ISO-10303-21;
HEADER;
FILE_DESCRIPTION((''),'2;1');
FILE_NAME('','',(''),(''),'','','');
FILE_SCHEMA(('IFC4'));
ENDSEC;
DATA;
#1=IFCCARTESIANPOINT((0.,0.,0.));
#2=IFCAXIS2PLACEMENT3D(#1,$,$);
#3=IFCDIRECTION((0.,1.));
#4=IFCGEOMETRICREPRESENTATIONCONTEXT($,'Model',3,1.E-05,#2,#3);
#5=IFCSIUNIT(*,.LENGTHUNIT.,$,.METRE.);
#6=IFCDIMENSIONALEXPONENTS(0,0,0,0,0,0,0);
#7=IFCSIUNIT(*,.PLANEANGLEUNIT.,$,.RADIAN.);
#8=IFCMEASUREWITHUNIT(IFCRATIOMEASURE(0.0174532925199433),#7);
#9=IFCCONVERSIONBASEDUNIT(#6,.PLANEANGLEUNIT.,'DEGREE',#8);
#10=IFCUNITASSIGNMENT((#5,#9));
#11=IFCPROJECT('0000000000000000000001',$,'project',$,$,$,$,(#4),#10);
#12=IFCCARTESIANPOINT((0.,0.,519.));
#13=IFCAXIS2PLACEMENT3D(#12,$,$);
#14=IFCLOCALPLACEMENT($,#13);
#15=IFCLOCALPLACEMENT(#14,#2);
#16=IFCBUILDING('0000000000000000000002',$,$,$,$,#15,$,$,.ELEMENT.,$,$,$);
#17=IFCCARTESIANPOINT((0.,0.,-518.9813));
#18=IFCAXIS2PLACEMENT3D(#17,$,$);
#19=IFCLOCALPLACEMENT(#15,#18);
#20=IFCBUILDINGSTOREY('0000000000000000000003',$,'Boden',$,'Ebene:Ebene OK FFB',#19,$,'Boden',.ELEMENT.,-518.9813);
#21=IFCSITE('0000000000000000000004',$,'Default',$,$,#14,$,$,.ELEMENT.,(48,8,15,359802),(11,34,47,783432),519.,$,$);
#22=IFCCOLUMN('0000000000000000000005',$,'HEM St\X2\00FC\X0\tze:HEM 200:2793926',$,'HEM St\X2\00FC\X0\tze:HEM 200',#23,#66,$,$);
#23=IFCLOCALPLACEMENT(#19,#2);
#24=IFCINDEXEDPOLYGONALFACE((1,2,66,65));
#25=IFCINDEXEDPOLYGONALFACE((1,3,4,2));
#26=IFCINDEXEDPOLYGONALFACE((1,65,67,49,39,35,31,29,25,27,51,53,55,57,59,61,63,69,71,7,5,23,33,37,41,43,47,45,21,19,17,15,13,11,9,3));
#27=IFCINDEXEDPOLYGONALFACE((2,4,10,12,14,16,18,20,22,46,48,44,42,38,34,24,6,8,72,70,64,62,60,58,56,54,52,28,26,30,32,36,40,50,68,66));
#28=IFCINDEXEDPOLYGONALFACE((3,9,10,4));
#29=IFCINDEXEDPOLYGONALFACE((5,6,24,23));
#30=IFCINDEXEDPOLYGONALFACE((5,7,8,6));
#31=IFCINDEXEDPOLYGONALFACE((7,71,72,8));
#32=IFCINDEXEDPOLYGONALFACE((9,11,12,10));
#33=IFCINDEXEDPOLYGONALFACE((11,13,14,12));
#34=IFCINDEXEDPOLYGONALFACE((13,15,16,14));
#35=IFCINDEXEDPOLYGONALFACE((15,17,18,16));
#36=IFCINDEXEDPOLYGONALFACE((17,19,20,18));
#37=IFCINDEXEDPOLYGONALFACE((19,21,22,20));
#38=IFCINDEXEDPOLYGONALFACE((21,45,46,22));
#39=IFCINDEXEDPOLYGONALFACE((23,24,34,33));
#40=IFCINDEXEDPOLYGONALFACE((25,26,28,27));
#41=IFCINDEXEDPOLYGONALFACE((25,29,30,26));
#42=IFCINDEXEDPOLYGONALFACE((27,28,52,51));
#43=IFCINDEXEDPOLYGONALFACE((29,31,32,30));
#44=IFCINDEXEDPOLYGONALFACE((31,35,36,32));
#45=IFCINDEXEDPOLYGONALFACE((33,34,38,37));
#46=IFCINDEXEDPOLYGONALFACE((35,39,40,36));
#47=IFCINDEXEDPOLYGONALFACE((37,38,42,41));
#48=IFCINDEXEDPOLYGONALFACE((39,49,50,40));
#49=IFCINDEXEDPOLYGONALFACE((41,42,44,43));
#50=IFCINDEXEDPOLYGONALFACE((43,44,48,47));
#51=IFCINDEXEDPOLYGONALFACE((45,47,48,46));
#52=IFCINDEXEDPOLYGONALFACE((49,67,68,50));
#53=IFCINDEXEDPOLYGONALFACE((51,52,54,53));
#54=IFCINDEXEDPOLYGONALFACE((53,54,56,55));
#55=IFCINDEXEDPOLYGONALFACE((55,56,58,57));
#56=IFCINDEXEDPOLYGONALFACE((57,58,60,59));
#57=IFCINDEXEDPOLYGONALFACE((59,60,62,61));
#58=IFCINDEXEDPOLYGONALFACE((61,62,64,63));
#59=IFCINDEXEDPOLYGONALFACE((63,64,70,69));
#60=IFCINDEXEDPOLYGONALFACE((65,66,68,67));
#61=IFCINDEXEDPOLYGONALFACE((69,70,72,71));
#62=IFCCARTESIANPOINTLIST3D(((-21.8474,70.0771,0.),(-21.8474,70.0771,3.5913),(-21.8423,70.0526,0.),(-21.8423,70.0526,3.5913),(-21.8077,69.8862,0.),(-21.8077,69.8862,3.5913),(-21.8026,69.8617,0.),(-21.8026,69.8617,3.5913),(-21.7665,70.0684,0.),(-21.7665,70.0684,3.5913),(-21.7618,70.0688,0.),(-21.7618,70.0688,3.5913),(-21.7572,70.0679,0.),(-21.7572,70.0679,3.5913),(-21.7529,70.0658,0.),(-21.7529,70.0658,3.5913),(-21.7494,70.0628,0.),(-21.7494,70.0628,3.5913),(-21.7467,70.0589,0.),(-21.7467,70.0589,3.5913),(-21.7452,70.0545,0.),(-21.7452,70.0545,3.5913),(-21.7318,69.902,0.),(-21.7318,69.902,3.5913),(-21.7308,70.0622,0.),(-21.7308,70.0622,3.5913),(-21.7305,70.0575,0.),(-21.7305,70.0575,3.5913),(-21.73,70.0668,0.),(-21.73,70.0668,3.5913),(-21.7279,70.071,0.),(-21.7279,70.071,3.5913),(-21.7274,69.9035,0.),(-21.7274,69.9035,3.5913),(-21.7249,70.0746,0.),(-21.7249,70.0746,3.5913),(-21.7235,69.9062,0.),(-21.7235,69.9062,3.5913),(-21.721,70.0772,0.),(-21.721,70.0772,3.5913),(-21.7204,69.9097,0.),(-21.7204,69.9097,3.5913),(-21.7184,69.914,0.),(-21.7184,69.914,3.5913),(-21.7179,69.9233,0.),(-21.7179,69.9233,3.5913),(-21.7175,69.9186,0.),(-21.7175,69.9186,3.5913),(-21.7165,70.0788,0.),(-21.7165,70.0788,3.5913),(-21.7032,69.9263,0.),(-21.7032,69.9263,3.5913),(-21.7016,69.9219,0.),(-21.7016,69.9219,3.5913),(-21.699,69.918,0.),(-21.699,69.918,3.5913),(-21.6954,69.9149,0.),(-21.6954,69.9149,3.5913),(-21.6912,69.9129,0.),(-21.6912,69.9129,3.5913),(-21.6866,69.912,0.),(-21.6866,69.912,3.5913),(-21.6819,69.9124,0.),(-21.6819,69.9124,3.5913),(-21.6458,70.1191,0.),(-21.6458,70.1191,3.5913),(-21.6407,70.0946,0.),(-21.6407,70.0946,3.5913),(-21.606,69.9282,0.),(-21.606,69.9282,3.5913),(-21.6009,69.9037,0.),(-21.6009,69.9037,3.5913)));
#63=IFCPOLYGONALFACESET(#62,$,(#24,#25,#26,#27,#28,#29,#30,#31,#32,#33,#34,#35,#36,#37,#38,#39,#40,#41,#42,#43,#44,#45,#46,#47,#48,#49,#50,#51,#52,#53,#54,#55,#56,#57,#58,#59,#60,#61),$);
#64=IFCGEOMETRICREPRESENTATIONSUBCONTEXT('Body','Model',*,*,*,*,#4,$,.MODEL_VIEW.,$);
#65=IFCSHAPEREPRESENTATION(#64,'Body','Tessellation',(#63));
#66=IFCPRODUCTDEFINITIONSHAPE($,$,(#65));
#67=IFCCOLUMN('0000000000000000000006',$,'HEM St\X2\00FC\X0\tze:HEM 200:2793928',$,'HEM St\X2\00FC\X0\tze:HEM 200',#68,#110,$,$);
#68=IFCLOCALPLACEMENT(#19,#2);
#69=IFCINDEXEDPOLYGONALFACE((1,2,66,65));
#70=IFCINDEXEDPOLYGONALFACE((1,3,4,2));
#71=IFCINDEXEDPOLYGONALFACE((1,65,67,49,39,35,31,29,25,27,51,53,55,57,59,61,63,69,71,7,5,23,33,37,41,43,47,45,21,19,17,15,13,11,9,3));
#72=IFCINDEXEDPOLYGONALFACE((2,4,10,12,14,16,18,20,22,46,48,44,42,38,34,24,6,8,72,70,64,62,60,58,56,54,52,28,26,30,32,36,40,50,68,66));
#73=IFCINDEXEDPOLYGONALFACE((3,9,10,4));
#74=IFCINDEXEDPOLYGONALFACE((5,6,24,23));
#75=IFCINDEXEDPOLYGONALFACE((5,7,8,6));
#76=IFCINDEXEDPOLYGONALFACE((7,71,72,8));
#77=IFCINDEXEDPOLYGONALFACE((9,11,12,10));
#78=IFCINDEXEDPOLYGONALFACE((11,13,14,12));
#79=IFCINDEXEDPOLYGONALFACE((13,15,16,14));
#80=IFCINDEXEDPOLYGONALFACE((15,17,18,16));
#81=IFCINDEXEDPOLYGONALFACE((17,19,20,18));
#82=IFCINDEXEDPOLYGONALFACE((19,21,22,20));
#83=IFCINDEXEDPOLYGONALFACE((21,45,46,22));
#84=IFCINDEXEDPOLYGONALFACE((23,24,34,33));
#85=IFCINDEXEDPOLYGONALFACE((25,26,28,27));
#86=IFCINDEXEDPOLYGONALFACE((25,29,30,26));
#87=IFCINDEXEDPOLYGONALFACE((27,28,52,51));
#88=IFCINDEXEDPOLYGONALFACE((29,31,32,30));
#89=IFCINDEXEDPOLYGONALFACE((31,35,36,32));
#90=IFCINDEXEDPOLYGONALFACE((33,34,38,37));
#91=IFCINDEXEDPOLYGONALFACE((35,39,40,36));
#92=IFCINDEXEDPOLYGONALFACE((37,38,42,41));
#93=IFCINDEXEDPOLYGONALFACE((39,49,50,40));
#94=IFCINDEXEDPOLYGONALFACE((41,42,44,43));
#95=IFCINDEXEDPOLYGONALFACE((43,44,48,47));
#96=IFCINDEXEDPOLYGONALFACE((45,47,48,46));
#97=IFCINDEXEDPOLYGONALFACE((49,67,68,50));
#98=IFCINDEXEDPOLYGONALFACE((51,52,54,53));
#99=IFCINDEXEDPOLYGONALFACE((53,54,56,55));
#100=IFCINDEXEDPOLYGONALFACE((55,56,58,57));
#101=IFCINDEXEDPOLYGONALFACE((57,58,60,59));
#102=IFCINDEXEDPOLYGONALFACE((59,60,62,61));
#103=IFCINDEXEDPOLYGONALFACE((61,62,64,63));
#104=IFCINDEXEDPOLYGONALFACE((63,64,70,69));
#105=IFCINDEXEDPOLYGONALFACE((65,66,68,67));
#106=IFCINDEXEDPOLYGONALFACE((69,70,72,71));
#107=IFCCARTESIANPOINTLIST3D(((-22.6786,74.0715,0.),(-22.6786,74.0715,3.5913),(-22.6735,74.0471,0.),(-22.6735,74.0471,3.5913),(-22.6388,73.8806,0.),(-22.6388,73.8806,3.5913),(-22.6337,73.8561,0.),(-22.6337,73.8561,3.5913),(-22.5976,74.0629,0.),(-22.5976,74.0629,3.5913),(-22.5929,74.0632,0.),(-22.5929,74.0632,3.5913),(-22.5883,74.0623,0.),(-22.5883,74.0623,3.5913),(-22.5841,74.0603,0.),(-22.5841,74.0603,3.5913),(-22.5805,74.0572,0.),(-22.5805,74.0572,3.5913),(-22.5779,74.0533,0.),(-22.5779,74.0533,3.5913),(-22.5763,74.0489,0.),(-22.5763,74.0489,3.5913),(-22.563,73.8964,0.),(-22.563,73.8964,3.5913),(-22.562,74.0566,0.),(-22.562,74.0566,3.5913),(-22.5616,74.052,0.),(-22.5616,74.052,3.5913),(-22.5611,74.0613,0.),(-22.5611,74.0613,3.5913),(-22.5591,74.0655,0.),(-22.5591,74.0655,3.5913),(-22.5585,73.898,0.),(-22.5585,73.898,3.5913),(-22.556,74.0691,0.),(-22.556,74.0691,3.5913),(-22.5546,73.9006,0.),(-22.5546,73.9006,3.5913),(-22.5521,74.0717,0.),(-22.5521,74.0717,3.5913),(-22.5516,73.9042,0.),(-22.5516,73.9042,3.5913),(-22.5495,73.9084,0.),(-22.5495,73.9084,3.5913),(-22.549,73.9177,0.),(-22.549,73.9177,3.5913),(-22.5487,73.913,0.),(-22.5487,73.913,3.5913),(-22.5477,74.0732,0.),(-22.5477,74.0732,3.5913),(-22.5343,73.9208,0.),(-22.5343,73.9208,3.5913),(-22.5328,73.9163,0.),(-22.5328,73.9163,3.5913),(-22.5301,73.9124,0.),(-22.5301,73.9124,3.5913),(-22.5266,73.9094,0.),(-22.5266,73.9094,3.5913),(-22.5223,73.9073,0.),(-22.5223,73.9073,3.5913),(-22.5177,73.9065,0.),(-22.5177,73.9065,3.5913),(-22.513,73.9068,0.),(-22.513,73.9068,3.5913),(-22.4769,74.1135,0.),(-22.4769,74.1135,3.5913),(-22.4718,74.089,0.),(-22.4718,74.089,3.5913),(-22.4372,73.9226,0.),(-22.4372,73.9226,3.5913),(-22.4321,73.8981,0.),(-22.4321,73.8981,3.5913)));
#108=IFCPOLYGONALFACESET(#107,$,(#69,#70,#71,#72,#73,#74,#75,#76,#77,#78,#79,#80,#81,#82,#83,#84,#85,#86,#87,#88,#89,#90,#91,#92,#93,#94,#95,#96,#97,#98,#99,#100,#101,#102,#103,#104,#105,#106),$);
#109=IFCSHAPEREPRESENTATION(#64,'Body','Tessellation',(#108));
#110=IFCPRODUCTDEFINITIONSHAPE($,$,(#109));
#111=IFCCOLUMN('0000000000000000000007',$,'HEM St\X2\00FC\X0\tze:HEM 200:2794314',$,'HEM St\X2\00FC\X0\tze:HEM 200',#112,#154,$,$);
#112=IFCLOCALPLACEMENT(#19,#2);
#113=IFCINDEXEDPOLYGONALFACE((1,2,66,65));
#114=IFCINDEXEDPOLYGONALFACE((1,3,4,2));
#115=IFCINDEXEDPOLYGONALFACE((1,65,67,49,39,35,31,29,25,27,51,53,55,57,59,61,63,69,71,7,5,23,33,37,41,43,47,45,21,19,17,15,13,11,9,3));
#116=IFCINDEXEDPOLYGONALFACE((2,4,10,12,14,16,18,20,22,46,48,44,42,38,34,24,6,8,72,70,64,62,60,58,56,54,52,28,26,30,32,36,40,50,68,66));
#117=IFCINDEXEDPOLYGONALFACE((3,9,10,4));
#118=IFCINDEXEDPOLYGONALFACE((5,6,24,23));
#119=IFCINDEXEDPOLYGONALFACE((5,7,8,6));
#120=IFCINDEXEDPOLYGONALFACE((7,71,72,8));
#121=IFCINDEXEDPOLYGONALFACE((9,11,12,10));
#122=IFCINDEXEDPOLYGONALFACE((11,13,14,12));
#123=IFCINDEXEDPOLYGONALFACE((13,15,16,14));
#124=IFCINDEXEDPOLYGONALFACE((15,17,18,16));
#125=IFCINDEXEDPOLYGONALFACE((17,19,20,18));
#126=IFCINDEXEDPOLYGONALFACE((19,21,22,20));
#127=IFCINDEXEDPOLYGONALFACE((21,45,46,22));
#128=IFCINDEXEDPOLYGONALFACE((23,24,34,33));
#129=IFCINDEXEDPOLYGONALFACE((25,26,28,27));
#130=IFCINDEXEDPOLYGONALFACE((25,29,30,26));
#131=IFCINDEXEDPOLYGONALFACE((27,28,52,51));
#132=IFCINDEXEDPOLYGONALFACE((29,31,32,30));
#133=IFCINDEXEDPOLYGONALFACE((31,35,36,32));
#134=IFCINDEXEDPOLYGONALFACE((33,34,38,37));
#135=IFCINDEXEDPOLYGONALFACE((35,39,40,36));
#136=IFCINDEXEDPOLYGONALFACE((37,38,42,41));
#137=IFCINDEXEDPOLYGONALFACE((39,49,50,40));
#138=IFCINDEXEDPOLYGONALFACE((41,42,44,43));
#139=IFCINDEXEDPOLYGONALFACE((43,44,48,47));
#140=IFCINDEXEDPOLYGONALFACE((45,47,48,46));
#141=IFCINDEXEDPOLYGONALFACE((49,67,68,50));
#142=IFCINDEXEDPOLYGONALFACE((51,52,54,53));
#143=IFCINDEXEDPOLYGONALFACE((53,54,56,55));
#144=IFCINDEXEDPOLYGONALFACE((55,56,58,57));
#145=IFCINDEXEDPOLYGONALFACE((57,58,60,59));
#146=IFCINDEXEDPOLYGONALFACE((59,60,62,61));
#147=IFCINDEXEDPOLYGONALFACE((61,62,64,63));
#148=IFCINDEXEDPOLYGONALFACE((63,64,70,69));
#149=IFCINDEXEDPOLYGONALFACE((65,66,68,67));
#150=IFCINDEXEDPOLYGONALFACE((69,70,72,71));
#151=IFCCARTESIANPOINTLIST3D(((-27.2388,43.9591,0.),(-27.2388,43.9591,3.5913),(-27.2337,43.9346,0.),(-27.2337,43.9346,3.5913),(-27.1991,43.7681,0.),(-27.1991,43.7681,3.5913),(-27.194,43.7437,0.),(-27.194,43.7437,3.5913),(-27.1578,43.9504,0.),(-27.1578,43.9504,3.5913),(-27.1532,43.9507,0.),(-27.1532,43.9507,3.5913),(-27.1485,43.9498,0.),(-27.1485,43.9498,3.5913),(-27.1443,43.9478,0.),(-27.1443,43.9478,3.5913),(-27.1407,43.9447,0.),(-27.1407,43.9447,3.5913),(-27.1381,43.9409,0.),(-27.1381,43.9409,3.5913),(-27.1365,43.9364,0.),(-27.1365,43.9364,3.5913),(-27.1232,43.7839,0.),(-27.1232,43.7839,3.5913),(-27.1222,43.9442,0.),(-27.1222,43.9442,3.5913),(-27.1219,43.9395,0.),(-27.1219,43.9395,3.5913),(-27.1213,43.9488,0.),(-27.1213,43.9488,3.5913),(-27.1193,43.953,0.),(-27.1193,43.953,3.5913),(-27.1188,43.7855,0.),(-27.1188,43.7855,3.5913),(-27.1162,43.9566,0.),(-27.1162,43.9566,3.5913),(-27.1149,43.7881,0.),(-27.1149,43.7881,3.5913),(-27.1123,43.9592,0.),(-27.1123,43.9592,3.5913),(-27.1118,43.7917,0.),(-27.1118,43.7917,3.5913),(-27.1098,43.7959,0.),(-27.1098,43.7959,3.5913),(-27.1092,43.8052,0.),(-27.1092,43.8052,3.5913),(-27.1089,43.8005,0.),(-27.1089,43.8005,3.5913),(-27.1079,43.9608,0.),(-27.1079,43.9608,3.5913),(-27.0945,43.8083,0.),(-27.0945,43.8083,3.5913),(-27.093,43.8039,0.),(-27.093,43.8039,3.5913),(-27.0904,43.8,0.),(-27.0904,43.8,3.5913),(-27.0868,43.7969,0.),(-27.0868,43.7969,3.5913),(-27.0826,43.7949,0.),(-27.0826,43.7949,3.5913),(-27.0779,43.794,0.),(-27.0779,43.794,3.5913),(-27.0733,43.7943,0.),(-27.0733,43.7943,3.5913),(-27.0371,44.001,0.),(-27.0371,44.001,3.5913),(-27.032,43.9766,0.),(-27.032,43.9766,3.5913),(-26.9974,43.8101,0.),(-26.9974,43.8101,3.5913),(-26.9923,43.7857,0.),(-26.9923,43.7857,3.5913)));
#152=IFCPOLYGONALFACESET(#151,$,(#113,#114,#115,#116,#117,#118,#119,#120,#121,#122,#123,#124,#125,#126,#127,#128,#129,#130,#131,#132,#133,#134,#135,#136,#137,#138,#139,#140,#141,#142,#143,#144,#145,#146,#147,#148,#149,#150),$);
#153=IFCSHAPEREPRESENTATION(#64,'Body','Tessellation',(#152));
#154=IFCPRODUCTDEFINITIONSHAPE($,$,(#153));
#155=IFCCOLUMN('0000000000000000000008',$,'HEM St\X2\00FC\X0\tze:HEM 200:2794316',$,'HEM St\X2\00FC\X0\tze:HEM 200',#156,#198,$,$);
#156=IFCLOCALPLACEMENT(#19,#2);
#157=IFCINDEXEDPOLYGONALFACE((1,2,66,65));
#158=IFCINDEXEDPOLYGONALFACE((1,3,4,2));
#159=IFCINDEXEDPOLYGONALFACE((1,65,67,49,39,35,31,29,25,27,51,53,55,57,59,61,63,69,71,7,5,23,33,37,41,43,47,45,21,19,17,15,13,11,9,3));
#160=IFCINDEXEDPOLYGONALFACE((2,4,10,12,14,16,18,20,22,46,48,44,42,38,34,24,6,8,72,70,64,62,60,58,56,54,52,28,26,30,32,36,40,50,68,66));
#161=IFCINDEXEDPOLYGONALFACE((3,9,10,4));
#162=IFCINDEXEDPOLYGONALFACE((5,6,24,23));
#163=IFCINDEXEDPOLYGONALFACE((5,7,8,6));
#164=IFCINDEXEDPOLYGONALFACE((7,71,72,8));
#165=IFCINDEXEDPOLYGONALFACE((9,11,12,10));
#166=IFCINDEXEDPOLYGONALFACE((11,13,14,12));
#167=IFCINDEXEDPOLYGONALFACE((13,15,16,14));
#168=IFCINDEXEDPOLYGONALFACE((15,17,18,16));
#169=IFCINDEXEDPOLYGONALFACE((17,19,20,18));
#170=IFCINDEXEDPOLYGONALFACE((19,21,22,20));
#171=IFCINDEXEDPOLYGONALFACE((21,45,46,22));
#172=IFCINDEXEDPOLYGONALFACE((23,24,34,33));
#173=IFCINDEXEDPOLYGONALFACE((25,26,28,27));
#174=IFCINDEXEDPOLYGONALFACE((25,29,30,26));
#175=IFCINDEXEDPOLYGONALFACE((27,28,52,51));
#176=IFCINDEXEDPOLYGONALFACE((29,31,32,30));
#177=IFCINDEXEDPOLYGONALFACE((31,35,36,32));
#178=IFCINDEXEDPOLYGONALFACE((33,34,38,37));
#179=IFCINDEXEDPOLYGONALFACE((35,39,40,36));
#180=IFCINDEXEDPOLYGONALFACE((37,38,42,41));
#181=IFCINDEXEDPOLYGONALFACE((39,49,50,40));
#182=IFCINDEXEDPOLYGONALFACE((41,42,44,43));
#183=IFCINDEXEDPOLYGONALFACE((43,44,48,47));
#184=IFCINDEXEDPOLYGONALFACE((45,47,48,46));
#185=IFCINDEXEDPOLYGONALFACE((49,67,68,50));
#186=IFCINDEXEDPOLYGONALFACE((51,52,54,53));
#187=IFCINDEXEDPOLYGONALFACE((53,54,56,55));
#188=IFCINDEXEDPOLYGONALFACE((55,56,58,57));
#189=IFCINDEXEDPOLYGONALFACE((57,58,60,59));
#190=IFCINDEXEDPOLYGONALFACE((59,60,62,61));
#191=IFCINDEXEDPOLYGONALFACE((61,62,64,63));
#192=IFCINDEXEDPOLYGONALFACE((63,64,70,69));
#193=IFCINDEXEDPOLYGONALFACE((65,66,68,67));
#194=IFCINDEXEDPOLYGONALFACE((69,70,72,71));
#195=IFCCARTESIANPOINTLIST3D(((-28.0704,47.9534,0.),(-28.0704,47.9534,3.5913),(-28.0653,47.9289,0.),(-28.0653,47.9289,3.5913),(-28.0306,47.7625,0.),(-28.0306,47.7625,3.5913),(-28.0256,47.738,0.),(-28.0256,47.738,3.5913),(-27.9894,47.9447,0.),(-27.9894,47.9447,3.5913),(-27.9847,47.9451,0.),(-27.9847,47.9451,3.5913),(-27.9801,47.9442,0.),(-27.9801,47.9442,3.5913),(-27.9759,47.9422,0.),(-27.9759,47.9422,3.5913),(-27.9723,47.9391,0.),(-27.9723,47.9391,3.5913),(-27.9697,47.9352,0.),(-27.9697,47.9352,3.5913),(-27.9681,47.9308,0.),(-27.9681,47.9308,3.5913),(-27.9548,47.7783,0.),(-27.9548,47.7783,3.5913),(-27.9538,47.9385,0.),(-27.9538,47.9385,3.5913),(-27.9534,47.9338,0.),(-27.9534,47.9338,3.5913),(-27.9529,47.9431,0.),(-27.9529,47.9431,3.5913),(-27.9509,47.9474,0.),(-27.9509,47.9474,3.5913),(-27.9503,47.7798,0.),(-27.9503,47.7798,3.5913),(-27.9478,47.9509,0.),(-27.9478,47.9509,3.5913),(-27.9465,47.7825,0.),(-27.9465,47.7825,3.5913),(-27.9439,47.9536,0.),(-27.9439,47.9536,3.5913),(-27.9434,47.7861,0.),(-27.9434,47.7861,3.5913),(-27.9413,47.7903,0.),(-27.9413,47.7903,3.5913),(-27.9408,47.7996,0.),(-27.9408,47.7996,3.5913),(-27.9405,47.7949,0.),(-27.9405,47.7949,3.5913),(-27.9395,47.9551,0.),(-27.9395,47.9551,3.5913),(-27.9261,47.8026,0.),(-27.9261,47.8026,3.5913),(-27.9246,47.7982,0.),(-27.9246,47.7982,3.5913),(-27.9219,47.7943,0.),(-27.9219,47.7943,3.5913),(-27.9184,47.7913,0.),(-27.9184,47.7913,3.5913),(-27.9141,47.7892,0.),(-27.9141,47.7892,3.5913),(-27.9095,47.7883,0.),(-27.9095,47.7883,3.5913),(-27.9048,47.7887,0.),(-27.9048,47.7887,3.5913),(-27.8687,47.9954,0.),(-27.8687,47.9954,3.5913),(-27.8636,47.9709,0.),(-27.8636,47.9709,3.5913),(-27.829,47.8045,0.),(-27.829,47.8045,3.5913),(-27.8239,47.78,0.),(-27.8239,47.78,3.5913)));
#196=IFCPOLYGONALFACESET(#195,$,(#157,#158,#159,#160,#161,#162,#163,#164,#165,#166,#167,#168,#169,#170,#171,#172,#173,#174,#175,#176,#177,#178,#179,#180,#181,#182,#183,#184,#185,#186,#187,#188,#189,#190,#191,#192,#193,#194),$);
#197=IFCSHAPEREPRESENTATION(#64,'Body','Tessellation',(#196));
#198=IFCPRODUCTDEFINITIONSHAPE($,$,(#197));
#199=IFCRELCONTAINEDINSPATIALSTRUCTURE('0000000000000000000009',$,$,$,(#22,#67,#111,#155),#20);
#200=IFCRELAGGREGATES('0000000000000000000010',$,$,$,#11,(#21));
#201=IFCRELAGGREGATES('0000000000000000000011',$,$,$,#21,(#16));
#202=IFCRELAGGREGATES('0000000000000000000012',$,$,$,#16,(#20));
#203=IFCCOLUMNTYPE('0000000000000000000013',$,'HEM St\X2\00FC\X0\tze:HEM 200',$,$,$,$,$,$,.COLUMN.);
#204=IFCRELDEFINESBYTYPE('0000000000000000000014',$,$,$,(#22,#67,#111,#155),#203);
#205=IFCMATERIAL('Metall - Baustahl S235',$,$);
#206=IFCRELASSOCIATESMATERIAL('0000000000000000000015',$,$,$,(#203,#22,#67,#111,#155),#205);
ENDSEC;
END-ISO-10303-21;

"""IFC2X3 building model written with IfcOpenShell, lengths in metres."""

from ifc_helpers import new_model, entity, si_unit, converted_unit, direction, frame, frame_2d, origin, place, context, subcontext, project, spatial, polyline, circle_curve, parameter, trimmed, segment, composite_curve, outline, extrude, source, transform, mapped, material, type_object, type_shapes, element, save


model = new_model("IFC2X3")

# Units and contexts
model_context = context("Model", 3, precision=1e-05, world=origin(), true_north=direction((0.0, 1.0)))
body_context = subcontext(model_context, "Body", "Model", "MODEL_VIEW")
ifc_project = project(units=[si_unit("LENGTHUNIT", "METRE"), converted_unit("PLANEANGLEUNIT", "DEGREE", entity("IfcRatioMeasure", 0.0174532925199433), si_unit("PLANEANGLEUNIT", "RADIAN"), dimensions=[0, 0, 0, 0, 0, 0, 0])], contexts=[model_context])

# Site, building, storey
site_placement = place(None, frame((0.0, 0.0, 519.0)))
site = spatial("IfcSite", under=ifc_project, at=site_placement, Name="Default", CompositionType="ELEMENT", RefLatitude=(48, 8, 15, 359802), RefLongitude=(11, 34, 47, 783432), RefElevation=519.0)
building_placement = place(site_placement, origin())
building = spatial("IfcBuilding", under=site, at=building_placement, CompositionType="ELEMENT")
storey_placement = place(building_placement, frame((0.0, 0.0, -518.9813)))
storey = spatial("IfcBuildingStorey", under=building, at=storey_placement, Name="Boden", ObjectType="Ebene:Ebene OK FFB", LongName="Boden", CompositionType="ELEMENT", Elevation=-518.9813)

# Columns
ifc_material = material(Name="Metall - Baustahl S235")
column_type = type_object("IfcColumnType", Name="HEM Stütze:HEM 200", PredefinedType="COLUMN", material=ifc_material)
shared_shape = source(origin(), body_context, "Body", "SweptSolid", [
    extrude(outline(composite_curve([segment(polyline([(0.085, -0.103), (0.11, -0.103)]), True, "CONTINUOUS"), segment(polyline([(0.11, -0.103), (0.11, 0.103)]), True, "CONTINUOUS"), segment(polyline([(0.11, 0.103), (0.085, 0.103)]), True, "CONTINUOUS"), segment(polyline([(0.085, 0.103), (0.085, 0.0255)]), True, "CONTINUOUS"), segment(trimmed(circle_curve(frame_2d((0.067, 0.0255), x_axis=(1.0, 0.0)), 0.018), [parameter(270.0)], [parameter(0.0)], True, "PARAMETER"), False, "CONTINUOUS"), segment(polyline([(0.067, 0.0075), (-0.067, 0.0075)]), True, "CONTINUOUS"), segment(trimmed(circle_curve(frame_2d((-0.067, 0.0255), x_axis=(0.0, -1.0)), 0.018), [parameter(270.0)], [parameter(0.0)], True, "PARAMETER"), False, "CONTINUOUS"), segment(polyline([(-0.085, 0.0255), (-0.085, 0.103)]), True, "CONTINUOUS"), segment(polyline([(-0.085, 0.103), (-0.11, 0.103)]), True, "CONTINUOUS"), segment(polyline([(-0.11, 0.103), (-0.11, -0.103)]), True, "CONTINUOUS"), segment(polyline([(-0.11, -0.103), (-0.085, -0.103)]), True, "CONTINUOUS"), segment(polyline([(-0.085, -0.103), (-0.085, -0.0255)]), True, "CONTINUOUS"), segment(trimmed(circle_curve(frame_2d((-0.067, -0.0255), x_axis=(-1.0, 0.0)), 0.018), [parameter(270.0)], [parameter(0.0)], True, "PARAMETER"), False, "CONTINUOUS"), segment(polyline([(-0.067, -0.0075), (0.067, -0.0075)]), True, "CONTINUOUS"), segment(trimmed(circle_curve(frame_2d((0.067, -0.0255), x_axis=(0.0, 1.0)), 0.018), [parameter(270.0)], [parameter(0.0)], True, "PARAMETER"), False, "CONTINUOUS"), segment(polyline([(0.085, -0.0255), (0.085, -0.103)]), True, "CONTINUOUS")], self_intersect=False)), frame((0.0, 0.0, -518.9813), z_axis=(0.0, 0.0, 1.0), x_axis=(0.0, -1.0, 0.0)), (0.0, 0.0, 1.0), 3.5913),
])
type_shapes(column_type, [shared_shape])
for number, where, z_axis, x_axis, name in (
    (1, (-21.7242, 69.9904, 518.9813), (0.0, 0.0, 1.0), (0.979008, 0.20382, 0.0), "HEM Stütze:HEM 200:2793926"),
    (2, (-22.5553, 73.9848, 518.9813), (0.0, 0.0, 1.0), (0.979008, 0.20382, 0.0), "HEM Stütze:HEM 200:2793928"),
    (3, (-27.1155, 43.8724, 518.9813), (0.0, 0.0, 1.0), (0.979008, 0.20382, 0.0), "HEM Stütze:HEM 200:2794314"),
    (4, (-27.9471, 47.8667, 518.9813), (0.0, 0.0, 1.0), (0.979008, 0.20382, 0.0), "HEM Stütze:HEM 200:2794316"),
):
    element("IfcColumn", number, at=place(storey_placement, frame(where, z_axis=z_axis, x_axis=x_axis)), inside=storey, type_object=column_type, material=ifc_material, Name=name, ObjectType="HEM Stütze:HEM 200", context=body_context, shape_type="MappedRepresentation", body=[
        mapped(shared_shape, transform((0.0, 0.0, 0.0), scale=1.0)),
    ])

save(model, "model.ifc")
